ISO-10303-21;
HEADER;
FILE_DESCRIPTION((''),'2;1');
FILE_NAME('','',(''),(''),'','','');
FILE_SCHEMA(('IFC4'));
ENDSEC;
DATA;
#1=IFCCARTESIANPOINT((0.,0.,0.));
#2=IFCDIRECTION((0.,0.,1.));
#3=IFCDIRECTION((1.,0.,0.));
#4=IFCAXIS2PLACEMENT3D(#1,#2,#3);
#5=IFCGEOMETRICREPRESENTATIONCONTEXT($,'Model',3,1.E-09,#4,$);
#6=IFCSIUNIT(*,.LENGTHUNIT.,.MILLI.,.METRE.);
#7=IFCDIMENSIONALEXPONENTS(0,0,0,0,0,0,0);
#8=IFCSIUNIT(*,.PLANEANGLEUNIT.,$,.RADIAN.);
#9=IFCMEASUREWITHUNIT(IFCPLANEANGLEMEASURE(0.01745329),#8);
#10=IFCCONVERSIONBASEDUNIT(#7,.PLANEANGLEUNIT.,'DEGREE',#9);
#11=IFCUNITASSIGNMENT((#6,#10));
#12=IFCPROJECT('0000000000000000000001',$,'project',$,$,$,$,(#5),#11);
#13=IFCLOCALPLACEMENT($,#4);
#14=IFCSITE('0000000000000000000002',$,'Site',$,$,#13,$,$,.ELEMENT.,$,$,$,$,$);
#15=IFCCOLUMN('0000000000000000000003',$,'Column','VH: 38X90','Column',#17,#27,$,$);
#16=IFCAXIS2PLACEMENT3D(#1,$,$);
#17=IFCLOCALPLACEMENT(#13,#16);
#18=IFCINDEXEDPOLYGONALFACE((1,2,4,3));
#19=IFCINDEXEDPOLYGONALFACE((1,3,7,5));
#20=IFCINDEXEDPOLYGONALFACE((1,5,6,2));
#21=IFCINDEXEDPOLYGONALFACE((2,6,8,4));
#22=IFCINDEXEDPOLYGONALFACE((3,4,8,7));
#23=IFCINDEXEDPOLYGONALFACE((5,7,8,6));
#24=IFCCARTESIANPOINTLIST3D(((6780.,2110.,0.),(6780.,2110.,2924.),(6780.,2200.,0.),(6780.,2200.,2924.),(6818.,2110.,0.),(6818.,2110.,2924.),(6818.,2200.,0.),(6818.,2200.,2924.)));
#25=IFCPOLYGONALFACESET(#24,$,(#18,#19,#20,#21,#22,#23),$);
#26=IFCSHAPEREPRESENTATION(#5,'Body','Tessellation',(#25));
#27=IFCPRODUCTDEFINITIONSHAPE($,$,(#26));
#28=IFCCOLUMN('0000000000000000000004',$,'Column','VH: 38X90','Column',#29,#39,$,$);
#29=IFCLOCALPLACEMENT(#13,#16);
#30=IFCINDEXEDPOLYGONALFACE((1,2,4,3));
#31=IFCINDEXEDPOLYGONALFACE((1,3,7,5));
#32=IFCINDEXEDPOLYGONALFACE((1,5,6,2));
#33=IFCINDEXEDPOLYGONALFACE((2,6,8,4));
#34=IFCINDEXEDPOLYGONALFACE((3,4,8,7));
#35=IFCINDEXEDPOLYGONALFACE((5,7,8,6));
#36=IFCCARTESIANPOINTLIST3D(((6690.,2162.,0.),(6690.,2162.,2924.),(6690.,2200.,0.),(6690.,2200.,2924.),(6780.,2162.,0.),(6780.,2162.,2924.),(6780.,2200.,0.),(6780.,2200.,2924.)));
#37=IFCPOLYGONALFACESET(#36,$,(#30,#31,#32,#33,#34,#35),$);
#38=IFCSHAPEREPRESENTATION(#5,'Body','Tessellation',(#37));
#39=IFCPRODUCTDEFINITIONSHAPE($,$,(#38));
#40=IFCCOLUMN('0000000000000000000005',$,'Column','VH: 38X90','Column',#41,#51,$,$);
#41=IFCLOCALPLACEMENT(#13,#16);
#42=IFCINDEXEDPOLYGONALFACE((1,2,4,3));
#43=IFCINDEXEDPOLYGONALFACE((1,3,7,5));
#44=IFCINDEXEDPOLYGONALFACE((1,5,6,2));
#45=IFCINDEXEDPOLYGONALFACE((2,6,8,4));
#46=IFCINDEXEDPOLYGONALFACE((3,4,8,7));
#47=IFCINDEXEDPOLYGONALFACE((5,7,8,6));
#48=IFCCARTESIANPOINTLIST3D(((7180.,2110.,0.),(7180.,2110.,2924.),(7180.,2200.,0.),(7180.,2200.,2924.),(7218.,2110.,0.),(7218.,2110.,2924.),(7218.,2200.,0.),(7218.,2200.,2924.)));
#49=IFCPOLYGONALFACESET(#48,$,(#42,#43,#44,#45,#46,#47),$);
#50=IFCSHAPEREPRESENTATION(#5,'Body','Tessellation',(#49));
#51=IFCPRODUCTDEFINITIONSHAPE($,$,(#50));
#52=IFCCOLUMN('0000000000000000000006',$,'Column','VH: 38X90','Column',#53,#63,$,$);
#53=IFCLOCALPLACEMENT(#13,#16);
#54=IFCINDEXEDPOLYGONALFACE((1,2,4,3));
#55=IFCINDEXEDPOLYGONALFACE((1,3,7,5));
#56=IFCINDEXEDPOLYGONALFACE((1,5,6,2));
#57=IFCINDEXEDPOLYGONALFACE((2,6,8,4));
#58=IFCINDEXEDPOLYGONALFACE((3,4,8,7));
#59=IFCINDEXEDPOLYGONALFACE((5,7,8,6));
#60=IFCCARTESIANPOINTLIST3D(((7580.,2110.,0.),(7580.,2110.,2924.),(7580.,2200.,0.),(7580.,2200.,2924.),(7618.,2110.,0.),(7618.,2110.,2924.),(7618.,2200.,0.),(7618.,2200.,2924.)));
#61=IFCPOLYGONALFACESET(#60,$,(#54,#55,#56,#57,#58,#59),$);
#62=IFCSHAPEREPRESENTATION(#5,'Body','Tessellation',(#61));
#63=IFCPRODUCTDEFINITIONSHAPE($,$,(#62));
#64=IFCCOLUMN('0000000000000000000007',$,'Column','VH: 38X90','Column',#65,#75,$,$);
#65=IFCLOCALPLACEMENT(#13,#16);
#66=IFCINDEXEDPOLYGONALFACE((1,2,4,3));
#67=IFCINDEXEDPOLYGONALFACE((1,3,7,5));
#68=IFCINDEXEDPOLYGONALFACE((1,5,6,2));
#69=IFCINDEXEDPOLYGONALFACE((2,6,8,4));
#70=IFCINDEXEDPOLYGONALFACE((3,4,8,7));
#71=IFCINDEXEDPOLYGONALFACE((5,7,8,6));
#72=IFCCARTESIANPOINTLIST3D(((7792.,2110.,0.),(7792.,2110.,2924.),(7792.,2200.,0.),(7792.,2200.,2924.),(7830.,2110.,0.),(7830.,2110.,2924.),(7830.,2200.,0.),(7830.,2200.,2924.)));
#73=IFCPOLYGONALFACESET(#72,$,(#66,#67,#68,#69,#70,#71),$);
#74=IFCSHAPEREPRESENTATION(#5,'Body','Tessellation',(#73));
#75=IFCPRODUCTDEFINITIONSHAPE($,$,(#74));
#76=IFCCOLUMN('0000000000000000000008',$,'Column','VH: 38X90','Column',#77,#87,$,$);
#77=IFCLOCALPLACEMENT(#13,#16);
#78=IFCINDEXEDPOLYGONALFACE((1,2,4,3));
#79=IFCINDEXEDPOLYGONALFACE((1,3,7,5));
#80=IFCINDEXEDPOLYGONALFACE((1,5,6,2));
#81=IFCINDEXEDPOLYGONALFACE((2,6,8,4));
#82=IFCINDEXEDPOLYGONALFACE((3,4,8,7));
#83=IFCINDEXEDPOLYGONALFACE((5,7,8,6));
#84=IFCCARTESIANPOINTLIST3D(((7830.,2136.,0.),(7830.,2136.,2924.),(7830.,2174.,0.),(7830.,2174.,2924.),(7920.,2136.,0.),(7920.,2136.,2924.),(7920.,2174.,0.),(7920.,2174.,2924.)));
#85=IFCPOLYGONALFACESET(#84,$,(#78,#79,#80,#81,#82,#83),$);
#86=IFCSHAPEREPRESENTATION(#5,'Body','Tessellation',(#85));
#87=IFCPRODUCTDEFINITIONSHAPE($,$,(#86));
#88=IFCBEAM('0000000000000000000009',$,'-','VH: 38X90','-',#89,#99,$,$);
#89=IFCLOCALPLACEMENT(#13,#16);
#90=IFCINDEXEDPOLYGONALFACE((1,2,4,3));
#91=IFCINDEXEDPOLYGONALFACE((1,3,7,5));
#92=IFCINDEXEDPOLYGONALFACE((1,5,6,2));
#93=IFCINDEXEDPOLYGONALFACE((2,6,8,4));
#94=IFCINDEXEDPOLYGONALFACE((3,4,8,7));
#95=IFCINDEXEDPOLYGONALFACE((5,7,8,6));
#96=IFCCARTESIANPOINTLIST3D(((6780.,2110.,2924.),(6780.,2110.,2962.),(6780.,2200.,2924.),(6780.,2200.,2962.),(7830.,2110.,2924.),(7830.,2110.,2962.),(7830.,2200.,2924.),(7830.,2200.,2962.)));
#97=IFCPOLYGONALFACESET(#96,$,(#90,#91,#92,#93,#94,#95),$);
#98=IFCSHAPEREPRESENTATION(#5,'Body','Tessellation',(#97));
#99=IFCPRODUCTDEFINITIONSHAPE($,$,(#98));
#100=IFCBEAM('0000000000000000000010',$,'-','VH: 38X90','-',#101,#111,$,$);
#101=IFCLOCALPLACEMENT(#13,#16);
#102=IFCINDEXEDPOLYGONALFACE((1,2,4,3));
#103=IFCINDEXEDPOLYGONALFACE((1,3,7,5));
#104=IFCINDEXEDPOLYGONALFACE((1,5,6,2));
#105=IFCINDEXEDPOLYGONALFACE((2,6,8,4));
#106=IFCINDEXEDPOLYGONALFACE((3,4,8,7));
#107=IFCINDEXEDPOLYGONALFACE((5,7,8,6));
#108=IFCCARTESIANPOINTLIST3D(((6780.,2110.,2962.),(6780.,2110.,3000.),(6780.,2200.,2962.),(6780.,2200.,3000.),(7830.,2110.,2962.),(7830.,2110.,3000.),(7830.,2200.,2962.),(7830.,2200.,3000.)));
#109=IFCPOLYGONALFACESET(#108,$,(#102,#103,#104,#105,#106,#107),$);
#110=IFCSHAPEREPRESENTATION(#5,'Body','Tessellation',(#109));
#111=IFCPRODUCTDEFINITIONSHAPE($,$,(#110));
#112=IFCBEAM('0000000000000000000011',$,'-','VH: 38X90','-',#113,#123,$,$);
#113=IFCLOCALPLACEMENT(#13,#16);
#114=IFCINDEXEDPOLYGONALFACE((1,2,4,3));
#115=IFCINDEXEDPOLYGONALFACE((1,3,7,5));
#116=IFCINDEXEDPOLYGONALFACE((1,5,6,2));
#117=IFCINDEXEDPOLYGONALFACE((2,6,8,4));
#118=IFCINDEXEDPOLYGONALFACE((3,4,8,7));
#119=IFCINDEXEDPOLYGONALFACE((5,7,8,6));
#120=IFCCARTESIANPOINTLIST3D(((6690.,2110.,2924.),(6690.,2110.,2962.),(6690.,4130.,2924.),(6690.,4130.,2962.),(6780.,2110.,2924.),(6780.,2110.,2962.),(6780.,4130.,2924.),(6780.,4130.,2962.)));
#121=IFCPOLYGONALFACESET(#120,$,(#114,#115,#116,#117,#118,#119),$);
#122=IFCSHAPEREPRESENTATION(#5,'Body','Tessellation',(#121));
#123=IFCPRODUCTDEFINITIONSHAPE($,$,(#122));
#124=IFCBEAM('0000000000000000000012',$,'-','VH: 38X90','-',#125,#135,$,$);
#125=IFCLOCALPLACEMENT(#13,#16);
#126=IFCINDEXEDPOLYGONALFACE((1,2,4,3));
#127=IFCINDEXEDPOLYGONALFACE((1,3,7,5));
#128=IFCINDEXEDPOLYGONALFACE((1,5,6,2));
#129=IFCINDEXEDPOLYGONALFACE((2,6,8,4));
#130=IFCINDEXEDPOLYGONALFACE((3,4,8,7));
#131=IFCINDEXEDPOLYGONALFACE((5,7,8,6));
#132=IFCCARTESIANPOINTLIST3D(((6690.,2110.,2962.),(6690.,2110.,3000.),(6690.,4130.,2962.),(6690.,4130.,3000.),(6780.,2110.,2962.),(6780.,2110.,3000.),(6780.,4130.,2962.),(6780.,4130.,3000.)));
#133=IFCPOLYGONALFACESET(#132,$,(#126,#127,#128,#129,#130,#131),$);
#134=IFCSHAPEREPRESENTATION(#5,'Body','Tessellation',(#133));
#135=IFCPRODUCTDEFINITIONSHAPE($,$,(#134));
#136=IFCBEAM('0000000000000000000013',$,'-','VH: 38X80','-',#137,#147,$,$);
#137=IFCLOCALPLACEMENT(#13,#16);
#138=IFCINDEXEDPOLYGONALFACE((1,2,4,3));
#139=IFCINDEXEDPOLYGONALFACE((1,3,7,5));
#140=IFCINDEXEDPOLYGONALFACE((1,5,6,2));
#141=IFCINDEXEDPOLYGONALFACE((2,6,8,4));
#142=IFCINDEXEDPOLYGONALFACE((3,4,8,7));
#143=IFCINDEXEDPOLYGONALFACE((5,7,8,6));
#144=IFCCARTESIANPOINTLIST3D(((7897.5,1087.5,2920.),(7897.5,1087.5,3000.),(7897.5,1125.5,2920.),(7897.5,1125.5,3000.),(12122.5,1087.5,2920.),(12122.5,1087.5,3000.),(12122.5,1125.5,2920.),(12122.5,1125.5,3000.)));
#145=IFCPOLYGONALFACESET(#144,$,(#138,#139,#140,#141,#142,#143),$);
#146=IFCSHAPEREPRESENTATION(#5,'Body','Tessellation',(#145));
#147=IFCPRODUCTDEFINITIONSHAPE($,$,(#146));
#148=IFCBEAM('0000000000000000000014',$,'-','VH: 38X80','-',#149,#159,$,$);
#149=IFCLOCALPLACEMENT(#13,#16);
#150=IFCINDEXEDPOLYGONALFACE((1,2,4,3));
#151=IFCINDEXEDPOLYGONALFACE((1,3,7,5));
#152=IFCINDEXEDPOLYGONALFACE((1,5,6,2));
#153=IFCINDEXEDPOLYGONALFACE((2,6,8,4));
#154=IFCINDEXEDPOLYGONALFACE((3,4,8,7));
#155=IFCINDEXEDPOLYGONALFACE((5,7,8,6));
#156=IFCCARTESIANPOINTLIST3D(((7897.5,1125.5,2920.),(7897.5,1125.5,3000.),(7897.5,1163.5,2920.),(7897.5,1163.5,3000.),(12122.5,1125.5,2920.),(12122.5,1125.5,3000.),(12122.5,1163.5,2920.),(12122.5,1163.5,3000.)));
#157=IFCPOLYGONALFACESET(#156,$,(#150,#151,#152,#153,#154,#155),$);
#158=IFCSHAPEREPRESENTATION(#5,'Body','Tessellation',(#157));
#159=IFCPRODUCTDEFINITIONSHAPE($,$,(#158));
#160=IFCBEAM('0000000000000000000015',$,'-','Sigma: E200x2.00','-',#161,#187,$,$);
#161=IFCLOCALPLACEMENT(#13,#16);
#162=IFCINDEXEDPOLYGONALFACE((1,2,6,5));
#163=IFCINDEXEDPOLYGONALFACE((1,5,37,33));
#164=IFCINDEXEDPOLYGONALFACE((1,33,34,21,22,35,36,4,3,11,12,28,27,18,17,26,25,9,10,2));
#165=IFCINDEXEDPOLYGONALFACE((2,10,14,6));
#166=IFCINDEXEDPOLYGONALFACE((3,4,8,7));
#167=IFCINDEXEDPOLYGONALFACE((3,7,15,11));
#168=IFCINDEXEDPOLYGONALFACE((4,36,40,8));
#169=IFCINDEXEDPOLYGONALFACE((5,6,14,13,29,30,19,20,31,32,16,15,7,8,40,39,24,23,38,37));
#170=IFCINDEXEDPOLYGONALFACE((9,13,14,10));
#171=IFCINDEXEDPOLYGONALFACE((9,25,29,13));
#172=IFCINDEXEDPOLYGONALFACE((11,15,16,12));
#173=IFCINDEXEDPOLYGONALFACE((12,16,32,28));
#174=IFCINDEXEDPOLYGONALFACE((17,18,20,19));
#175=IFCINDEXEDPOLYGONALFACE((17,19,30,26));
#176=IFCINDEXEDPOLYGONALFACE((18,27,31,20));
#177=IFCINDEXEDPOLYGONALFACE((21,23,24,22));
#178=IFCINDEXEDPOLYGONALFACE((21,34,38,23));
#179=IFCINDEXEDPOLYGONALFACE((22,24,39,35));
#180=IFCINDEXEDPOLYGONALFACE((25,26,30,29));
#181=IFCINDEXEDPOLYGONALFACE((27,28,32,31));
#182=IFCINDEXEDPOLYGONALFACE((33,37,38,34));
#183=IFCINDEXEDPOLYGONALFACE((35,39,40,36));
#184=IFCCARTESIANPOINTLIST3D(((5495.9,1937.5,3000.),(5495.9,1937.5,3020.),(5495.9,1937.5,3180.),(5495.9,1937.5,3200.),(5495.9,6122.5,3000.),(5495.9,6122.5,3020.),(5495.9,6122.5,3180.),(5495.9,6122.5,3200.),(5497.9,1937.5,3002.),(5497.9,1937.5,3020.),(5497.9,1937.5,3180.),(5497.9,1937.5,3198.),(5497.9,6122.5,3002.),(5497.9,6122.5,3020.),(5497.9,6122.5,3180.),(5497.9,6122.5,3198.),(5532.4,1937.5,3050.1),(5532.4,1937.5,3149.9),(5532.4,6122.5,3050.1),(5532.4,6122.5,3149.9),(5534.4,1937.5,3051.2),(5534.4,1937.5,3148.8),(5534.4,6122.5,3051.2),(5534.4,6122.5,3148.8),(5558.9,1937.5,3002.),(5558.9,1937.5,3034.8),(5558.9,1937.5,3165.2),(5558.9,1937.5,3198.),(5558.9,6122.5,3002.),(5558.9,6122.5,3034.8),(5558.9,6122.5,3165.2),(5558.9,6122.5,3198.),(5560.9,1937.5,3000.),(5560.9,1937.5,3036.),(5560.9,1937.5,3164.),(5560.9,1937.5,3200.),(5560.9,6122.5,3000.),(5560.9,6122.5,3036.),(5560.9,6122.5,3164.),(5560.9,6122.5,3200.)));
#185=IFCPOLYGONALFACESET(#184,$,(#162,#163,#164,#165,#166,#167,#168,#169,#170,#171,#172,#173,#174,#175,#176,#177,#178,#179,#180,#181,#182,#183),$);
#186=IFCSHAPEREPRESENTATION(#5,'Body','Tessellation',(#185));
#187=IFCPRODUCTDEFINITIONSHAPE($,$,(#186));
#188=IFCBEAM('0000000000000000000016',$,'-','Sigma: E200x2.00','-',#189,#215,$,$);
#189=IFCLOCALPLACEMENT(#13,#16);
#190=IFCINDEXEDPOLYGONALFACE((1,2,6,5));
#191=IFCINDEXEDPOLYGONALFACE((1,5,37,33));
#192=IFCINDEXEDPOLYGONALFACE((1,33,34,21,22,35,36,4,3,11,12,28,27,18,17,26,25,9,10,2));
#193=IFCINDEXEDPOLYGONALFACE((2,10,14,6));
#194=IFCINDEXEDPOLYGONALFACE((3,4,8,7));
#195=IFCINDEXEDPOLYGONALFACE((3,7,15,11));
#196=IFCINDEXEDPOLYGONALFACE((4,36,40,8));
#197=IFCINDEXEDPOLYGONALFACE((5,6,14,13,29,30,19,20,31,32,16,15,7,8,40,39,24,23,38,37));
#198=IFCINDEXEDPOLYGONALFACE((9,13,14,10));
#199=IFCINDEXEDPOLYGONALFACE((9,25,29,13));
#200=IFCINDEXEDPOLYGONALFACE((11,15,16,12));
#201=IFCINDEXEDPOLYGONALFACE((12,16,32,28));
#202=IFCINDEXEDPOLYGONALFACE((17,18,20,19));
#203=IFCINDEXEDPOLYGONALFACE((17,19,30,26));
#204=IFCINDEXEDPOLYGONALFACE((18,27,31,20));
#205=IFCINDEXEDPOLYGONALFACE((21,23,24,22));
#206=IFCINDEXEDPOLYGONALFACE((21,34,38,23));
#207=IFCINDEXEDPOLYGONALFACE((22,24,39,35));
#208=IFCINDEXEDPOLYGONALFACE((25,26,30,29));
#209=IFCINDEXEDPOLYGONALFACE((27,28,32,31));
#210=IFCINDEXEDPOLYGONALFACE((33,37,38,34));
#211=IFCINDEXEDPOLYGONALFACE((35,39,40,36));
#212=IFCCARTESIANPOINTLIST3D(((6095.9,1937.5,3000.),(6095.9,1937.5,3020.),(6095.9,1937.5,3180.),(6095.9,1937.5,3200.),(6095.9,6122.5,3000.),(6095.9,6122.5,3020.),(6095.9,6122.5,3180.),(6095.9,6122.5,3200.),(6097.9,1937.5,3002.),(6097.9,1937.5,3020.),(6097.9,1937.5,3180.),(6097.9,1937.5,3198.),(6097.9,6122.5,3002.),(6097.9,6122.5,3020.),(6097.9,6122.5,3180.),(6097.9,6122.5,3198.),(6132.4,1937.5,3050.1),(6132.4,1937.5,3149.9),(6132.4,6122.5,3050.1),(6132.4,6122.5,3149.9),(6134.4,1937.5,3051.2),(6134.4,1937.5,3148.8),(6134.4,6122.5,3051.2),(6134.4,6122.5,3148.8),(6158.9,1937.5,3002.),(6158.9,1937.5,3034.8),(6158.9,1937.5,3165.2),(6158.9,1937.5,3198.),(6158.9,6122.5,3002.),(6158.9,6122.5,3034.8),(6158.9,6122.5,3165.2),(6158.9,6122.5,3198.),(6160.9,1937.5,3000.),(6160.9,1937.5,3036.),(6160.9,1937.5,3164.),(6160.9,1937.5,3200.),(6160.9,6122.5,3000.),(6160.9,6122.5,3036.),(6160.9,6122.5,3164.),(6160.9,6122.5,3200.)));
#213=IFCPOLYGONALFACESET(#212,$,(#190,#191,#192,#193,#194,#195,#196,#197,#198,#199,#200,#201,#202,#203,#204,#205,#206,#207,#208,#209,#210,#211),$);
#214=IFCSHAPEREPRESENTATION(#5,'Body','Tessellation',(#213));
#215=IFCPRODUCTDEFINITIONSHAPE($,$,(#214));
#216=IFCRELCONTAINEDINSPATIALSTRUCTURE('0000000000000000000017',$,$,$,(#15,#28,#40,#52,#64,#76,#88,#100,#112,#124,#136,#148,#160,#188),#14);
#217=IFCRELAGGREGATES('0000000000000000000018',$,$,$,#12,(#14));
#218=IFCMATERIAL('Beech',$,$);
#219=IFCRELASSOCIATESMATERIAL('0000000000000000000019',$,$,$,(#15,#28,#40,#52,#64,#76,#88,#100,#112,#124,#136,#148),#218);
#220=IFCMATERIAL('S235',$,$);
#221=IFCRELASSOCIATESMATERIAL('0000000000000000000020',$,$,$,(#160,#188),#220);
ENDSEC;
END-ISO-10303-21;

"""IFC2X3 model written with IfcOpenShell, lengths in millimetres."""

from ifc_helpers import new_model, entity, si_unit, converted_unit, frame, origin, origin_with_axes, origin_2d, place, context, project, spatial, polyline, rectangle, outline, extrude, material, element, save


model = new_model("IFC2X3")

# Units and contexts
model_context = context("Model", 3, precision=1e-09, world=origin_with_axes())
ifc_project = project(units=[si_unit("LENGTHUNIT", "METRE", prefix="MILLI"), converted_unit("PLANEANGLEUNIT", "DEGREE", entity("IfcPlaneAngleMeasure", 0.01745329), si_unit("PLANEANGLEUNIT", "RADIAN"), dimensions=[0, 0, 0, 0, 0, 0, 0])], contexts=[model_context])

# Site
site_placement = place(None, origin_with_axes())
site = spatial("IfcSite", under=ifc_project, at=site_placement, Name="Site", CompositionType="ELEMENT")

# Columns
ifc_material_1 = material(Name="Beech")
for number, where, z_axis, x_axis, name in (
    (1, (6799.0, 2155.0, 0.0), (0.0, 0.0, -1.0), (-1.0, 0.0, 0.0), "Column"),
    (2, (6735.0, 2181.0, 0.0), (0.0, 0.0, -1.0), (0.0, -1.0, 0.0), "Column"),
    (3, (7199.0, 2155.0, 0.0), (0.0, 0.0, -1.0), (-1.0, 0.0, 0.0), "Column"),
    (4, (7599.0, 2155.0, 0.0), (0.0, 0.0, -1.0), (-1.0, 0.0, 0.0), "Column"),
    (5, (7811.0, 2155.0, 0.0), (0.0, 0.0, -1.0), (-1.0, 0.0, 0.0), "Column"),
    (6, (7875.0, 2155.0, 0.0), (0.0, 0.0, -1.0), (0.0, -1.0, 0.0), "Column"),
):
    element("IfcColumn", number, at=place(None, frame(where, z_axis=z_axis, x_axis=x_axis)), inside=site, material=ifc_material_1, Name=name, Description="VH: 38X90", ObjectType="Column", context=model_context, shape_type="SweptSolid", body=[
        extrude(rectangle(XDim=38.0, YDim=90.0, at=origin_2d()), origin(), (0.0, 0.0, -1.0), 2924.0),
    ])

# Beams
for number, where, z_axis, x_axis, name in (
    (7, (6780.0, 2155.0, 2943.0), (-1.0, 0.0, 0.0), (0.0, 0.0, -1.0), "-"),
    (8, (6780.0, 2155.0, 2981.0), (-1.0, 0.0, 0.0), (0.0, 0.0, -1.0), "-"),
):
    element("IfcBeam", number, at=place(None, frame(where, z_axis=z_axis, x_axis=x_axis)), inside=site, material=ifc_material_1, Name=name, Description="VH: 38X90", ObjectType="-", context=model_context, shape_type="SweptSolid", body=[
        extrude(rectangle(XDim=38.0, YDim=90.0, at=origin_2d()), origin(), (0.0, 0.0, -1.0), 1050.0),
    ])
for number, where, z_axis, x_axis, name in (
    (9, (6735.0, 2110.0, 2943.0), (0.0, -1.0, 0.0), (0.0, 0.0, -1.0), "-"),
    (10, (6735.0, 2110.0, 2981.0), (0.0, -1.0, 0.0), (0.0, 0.0, -1.0), "-"),
):
    element("IfcBeam", number, at=place(None, frame(where, z_axis=z_axis, x_axis=x_axis)), inside=site, material=ifc_material_1, Name=name, Description="VH: 38X90", ObjectType="-", context=model_context, shape_type="SweptSolid", body=[
        extrude(rectangle(XDim=38.0, YDim=90.0, at=origin_2d()), origin(), (0.0, 0.0, -1.0), 2020.0),
    ])
for number, where, z_axis, x_axis, name in (
    (11, (7897.5, 1106.5, 2960.0), (-1.0, 0.0, 0.0), (0.0, -1.0, 0.0), "-"),
    (12, (7897.5, 1144.5, 2960.0), (-1.0, 0.0, 0.0), (0.0, -1.0, 0.0), "-"),
):
    element("IfcBeam", number, at=place(None, frame(where, z_axis=z_axis, x_axis=x_axis)), inside=site, material=ifc_material_1, Name=name, Description="VH: 38X80", ObjectType="-", context=model_context, shape_type="SweptSolid", body=[
        extrude(rectangle(XDim=38.0, YDim=80.0, at=origin_2d()), origin(), (0.0, 0.0, -1.0), 4225.0),
    ])
ifc_material_2 = material(Name="S235")
for number, where, z_axis, x_axis, name in (
    (13, (5535.0, 1937.5, 3100.0), (0.0, 1.0, 0.0), (-1.0, 0.0, 0.0), "-"),
    (14, (6135.0, 1937.5, 3100.0), (0.0, 1.0, 0.0), (-1.0, 0.0, 0.0), "-"),
):
    element("IfcBeam", number, at=place(None, frame(where, z_axis=z_axis, x_axis=x_axis)), inside=site, material=ifc_material_2, Name=name, Description="Sigma: E200x2.00", ObjectType="-", context=model_context, shape_type="SweptSolid", body=[
        extrude(outline(polyline([(39.1, -100.0), (39.1, -80.0), (37.1, -80.0), (37.1, -98.0), (-23.9, -98.0), (-23.9, -65.2), (2.6, -49.9), (2.6, 49.9), (-23.9, 65.2), (-23.9, 98.0), (37.1, 98.0), (37.1, 80.0), (39.1, 80.0), (39.1, 100.0), (-25.9, 100.0), (-25.9, 64.0), (0.6, 48.8), (0.6, -48.8), (-25.9, -64.0), (-25.9, -100.0), (39.1, -100.0)])), origin(), (0.0, 0.0, 1.0), 4185.0),
    ])

save(model, "model.ifc")
